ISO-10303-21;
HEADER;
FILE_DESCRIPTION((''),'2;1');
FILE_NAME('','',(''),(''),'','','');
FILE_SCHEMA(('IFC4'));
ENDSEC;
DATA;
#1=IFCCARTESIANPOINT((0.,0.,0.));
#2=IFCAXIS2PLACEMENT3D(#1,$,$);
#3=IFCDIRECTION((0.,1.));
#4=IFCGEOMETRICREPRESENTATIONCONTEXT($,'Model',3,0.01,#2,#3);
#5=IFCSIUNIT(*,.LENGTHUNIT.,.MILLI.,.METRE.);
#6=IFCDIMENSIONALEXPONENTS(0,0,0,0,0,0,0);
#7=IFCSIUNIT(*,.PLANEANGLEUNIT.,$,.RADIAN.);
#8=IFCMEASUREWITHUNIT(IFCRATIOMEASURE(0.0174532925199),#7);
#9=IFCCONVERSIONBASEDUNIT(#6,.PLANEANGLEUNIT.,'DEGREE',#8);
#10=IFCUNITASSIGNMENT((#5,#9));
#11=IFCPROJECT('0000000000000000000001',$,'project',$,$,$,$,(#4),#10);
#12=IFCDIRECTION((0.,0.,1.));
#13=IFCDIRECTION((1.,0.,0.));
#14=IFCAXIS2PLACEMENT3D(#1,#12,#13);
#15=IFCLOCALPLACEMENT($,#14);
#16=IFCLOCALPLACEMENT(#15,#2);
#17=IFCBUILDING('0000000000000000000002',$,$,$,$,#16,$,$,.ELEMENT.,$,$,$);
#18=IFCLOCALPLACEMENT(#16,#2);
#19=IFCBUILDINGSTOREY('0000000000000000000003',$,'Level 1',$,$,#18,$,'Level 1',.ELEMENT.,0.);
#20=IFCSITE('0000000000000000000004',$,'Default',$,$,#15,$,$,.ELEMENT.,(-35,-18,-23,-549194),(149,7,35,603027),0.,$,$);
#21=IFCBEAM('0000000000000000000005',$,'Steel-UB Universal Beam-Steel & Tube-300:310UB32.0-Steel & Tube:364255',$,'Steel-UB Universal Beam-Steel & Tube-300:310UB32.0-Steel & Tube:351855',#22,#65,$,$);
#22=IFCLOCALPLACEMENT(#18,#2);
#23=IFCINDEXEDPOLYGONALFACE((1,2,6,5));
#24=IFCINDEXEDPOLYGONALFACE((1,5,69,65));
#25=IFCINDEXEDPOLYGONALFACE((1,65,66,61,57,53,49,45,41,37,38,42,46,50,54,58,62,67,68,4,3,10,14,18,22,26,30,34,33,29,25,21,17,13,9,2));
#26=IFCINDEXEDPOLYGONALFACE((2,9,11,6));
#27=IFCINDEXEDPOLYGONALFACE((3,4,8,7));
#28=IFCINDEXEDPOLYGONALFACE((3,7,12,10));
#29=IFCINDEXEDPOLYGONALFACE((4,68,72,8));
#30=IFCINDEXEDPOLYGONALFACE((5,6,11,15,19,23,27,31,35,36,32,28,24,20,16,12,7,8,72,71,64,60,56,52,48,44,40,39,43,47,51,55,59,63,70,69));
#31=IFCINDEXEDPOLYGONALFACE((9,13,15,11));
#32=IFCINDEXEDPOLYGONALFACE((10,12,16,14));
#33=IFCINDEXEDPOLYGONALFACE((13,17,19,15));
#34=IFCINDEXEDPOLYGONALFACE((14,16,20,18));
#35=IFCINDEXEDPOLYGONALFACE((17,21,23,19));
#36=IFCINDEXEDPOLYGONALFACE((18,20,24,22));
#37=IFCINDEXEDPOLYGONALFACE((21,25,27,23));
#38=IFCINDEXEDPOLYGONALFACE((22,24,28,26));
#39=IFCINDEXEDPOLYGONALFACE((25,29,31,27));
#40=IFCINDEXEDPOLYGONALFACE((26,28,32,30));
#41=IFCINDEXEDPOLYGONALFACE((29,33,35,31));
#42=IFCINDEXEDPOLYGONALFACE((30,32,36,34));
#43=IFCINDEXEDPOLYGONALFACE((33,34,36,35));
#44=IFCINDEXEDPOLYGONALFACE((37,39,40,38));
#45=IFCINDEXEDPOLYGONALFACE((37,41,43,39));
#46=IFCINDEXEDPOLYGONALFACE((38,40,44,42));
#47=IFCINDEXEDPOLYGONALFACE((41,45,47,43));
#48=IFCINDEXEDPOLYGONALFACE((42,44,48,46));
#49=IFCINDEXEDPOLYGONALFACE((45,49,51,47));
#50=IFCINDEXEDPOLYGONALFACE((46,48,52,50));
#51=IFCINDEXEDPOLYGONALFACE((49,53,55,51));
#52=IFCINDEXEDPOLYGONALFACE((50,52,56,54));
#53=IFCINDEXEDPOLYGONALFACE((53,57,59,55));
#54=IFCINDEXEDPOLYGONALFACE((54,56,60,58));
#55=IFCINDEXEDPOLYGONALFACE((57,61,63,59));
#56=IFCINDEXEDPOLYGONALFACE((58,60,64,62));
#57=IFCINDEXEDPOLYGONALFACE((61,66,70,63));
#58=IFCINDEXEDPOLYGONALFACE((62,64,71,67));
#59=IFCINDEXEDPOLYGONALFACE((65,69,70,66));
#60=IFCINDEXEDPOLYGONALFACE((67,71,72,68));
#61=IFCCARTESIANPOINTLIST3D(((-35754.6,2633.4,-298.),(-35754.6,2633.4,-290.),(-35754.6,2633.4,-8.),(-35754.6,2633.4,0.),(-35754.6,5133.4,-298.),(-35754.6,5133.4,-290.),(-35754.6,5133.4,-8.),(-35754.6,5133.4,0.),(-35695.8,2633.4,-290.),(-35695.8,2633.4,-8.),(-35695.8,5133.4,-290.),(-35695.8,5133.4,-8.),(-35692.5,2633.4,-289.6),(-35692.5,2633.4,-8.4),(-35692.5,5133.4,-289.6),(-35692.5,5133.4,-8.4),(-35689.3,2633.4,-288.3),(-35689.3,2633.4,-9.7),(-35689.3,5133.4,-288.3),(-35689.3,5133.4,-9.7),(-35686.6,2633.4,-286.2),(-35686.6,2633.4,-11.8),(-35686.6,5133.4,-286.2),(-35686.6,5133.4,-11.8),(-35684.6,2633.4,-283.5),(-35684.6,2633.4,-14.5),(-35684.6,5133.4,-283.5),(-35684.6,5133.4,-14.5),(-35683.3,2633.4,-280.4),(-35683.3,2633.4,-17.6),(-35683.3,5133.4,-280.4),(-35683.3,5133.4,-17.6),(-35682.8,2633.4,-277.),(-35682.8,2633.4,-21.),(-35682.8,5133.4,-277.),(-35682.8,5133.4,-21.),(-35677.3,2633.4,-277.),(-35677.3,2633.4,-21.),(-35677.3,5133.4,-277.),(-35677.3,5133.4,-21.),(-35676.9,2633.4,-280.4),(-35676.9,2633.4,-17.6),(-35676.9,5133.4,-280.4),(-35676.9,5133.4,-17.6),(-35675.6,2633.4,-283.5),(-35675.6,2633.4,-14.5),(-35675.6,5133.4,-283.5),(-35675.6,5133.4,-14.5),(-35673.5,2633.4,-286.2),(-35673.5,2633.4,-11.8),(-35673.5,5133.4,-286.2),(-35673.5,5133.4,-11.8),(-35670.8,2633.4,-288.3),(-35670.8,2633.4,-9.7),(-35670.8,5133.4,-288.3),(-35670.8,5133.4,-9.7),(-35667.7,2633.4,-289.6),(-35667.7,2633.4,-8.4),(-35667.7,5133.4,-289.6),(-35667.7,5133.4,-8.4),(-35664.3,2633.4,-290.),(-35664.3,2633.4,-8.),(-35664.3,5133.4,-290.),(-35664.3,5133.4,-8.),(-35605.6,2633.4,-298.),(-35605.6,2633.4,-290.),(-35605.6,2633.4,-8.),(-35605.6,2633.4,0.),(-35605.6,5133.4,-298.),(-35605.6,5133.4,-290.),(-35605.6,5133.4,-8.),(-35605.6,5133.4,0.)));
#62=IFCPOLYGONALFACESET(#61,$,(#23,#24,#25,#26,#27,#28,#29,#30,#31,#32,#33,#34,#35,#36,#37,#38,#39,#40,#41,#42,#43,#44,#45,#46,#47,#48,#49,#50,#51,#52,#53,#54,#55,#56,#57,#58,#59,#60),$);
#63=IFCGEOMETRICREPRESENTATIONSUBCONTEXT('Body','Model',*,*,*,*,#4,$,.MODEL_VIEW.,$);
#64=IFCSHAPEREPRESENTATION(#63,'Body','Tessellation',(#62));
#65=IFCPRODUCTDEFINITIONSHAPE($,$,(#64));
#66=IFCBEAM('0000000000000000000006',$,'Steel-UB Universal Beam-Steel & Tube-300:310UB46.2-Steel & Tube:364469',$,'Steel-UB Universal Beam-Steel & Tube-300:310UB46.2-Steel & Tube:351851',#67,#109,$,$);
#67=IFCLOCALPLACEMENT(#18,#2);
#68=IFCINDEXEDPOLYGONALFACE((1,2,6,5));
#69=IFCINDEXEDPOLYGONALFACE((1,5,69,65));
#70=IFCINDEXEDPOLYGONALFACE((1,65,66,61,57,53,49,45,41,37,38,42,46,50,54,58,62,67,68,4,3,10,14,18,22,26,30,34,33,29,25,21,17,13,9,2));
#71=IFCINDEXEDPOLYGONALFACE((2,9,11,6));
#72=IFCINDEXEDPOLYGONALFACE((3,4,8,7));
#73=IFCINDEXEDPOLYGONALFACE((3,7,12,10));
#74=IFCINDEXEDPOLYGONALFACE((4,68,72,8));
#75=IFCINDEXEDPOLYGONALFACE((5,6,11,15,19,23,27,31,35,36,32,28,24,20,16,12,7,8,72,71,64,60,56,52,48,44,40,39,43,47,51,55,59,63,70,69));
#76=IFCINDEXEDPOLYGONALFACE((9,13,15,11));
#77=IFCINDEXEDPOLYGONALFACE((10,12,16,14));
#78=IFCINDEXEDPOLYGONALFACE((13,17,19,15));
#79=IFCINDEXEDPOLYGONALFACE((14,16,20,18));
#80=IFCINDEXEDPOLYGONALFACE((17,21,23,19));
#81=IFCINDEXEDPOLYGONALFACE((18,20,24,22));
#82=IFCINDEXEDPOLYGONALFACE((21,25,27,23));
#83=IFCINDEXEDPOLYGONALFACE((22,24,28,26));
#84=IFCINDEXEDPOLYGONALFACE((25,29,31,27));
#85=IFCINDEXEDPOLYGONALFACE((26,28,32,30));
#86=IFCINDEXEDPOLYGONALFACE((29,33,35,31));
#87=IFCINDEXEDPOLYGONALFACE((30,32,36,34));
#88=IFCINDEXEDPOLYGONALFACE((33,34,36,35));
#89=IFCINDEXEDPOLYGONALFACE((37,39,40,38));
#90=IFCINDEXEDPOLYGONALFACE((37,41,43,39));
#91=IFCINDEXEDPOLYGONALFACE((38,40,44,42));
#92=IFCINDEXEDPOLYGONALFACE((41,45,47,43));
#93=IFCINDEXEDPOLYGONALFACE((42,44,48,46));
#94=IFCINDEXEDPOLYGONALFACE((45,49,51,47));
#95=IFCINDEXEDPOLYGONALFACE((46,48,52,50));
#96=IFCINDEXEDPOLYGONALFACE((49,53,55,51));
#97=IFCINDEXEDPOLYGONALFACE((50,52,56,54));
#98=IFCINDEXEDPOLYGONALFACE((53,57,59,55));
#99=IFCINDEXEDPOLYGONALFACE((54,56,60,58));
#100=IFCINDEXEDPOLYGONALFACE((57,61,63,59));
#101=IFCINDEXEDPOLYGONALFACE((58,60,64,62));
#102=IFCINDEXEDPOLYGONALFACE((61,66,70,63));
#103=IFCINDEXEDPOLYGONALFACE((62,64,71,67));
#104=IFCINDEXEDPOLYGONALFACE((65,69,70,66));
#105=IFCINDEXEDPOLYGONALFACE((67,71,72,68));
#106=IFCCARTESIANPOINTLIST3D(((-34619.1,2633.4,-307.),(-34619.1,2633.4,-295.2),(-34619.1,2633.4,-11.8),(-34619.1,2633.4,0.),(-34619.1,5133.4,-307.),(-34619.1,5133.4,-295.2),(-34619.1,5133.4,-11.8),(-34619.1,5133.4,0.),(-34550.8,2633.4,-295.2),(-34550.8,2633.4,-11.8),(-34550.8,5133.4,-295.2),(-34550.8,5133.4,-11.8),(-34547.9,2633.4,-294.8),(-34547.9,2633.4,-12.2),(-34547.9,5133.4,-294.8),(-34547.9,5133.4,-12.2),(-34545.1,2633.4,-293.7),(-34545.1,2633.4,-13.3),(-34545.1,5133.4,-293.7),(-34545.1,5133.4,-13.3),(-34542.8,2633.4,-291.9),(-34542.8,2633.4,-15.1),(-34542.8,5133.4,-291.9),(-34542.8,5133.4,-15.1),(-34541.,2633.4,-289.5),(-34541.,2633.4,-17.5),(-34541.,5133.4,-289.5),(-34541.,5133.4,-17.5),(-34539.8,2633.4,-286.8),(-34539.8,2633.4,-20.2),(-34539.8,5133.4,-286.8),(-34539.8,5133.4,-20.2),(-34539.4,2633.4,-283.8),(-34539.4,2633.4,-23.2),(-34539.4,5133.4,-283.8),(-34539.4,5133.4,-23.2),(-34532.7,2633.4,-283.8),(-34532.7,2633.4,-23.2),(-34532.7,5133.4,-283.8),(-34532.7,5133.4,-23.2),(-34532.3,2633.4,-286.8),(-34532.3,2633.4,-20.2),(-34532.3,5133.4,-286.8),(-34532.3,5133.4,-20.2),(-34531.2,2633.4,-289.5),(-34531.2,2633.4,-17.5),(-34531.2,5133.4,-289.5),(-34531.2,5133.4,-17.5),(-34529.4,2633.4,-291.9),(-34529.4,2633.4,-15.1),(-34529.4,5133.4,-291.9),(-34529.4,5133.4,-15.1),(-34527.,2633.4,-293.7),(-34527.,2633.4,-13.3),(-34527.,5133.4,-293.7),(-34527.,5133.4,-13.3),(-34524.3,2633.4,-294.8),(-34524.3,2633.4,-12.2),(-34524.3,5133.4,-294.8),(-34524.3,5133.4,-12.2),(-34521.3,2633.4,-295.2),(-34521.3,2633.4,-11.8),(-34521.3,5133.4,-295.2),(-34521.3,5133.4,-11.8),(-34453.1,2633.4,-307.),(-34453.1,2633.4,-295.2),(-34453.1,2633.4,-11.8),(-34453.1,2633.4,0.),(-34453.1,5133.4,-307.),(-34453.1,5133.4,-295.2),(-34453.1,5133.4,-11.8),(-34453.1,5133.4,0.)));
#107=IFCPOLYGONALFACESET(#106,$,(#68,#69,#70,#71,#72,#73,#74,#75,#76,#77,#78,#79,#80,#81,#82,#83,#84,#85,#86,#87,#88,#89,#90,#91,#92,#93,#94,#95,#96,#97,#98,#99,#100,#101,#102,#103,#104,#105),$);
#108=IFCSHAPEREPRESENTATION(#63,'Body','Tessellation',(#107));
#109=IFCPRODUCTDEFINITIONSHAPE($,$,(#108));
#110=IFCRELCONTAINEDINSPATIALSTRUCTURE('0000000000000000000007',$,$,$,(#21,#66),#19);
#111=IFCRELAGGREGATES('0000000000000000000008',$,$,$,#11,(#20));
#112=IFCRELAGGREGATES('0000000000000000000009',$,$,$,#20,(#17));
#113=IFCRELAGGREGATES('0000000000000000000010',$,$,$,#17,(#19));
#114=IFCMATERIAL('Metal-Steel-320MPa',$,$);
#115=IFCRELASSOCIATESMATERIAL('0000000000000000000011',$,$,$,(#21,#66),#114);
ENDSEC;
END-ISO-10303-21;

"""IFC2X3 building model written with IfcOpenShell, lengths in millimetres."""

from ifc_helpers import new_model, entity, si_unit, converted_unit, direction, frame, frame_2d, origin, origin_with_axes, place, context, subcontext, project, spatial, polyline, circle_curve, parameter, trimmed, segment, composite_curve, outline, extrude, material, element, save


model = new_model("IFC2X3")

# Units and contexts
model_context = context("Model", 3, precision=0.01, world=origin(), true_north=direction((0.0, 1.0)))
body_context = subcontext(model_context, "Body", "Model", "MODEL_VIEW")
ifc_project = project(units=[si_unit("LENGTHUNIT", "METRE", prefix="MILLI"), converted_unit("PLANEANGLEUNIT", "DEGREE", entity("IfcRatioMeasure", 0.0174532925199), si_unit("PLANEANGLEUNIT", "RADIAN"), dimensions=[0, 0, 0, 0, 0, 0, 0])], contexts=[model_context])

# Site, building, storey
site_placement = place(None, origin_with_axes())
site = spatial("IfcSite", under=ifc_project, at=site_placement, Name="Default", CompositionType="ELEMENT", RefLatitude=(-35, -18, -23, -549194), RefLongitude=(149, 7, 35, 603027), RefElevation=0.0)
building_placement = place(site_placement, origin())
building = spatial("IfcBuilding", under=site, at=building_placement, CompositionType="ELEMENT")
storey_placement = place(building_placement, origin())
storey = spatial("IfcBuildingStorey", under=building, at=storey_placement, Name="Level 1", LongName="Level 1", CompositionType="ELEMENT", Elevation=0.0)

# Beams
ifc_material = material(Name="Metal-Steel-320MPa")
beam_1_placement = place(storey_placement, frame((-35680.1, 5133.4, 0.0), z_axis=(0.0, 0.0, 1.0), x_axis=(0.0, -1.0, 0.0)))
element("IfcBeam", 1, at=beam_1_placement, inside=storey, material=ifc_material, Name="Steel-UB Universal Beam-Steel & Tube-300:310UB32.0-Steel & Tube:364255", ObjectType="Steel-UB Universal Beam-Steel & Tube-300:310UB32.0-Steel & Tube:351855", context=body_context, shape_type="SweptSolid", body=[
    extrude(outline(composite_curve([segment(polyline([(141.0, -74.5), (149.0, -74.5)]), True, "CONTINUOUS"), segment(polyline([(149.0, -74.5), (149.0, 74.5)]), True, "CONTINUOUS"), segment(polyline([(149.0, 74.5), (141.0, 74.5)]), True, "CONTINUOUS"), segment(polyline([(141.0, 74.5), (141.0, 15.8)]), True, "CONTINUOUS"), segment(trimmed(circle_curve(frame_2d((128.0, 15.8), x_axis=(1.0, 0.0)), 13.0), [parameter(270.0)], [parameter(0.0)], True, "PARAMETER"), False, "CONTINUOUS"), segment(polyline([(128.0, 2.8), (-128.0, 2.8)]), True, "CONTINUOUS"), segment(trimmed(circle_curve(frame_2d((-128.0, 15.8), x_axis=(0.0, -1.0)), 13.0), [parameter(270.0)], [parameter(0.0)], True, "PARAMETER"), False, "CONTINUOUS"), segment(polyline([(-141.0, 15.8), (-141.0, 74.5)]), True, "CONTINUOUS"), segment(polyline([(-141.0, 74.5), (-149.0, 74.5)]), True, "CONTINUOUS"), segment(polyline([(-149.0, 74.5), (-149.0, -74.5)]), True, "CONTINUOUS"), segment(polyline([(-149.0, -74.5), (-141.0, -74.5)]), True, "CONTINUOUS"), segment(polyline([(-141.0, -74.5), (-141.0, -15.8)]), True, "CONTINUOUS"), segment(trimmed(circle_curve(frame_2d((-128.0, -15.8), x_axis=(-1.0, 0.0)), 13.0), [parameter(270.0)], [parameter(0.0)], True, "PARAMETER"), False, "CONTINUOUS"), segment(polyline([(-128.0, -2.8), (128.0, -2.8)]), True, "CONTINUOUS"), segment(trimmed(circle_curve(frame_2d((128.0, -15.8), x_axis=(0.0, 1.0)), 13.0), [parameter(270.0)], [parameter(0.0)], True, "PARAMETER"), False, "CONTINUOUS"), segment(polyline([(141.0, -15.8), (141.0, -74.5)]), True, "CONTINUOUS")], self_intersect=False)), frame((0.0, 0.0, -149.0), z_axis=(1.0, 0.0, 0.0), x_axis=(0.0, 0.0, -1.0)), (0.0, 0.0, 1.0), 2500.0),
])
beam_2_placement = place(storey_placement, frame((-34536.1, 5133.4, 0.0), z_axis=(0.0, 0.0, 1.0), x_axis=(0.0, -1.0, 0.0)))
element("IfcBeam", 2, at=beam_2_placement, inside=storey, material=ifc_material, Name="Steel-UB Universal Beam-Steel & Tube-300:310UB46.2-Steel & Tube:364469", ObjectType="Steel-UB Universal Beam-Steel & Tube-300:310UB46.2-Steel & Tube:351851", context=body_context, shape_type="SweptSolid", body=[
    extrude(outline(composite_curve([segment(polyline([(141.7, -83.0), (153.5, -83.0)]), True, "CONTINUOUS"), segment(polyline([(153.5, -83.0), (153.5, 83.0)]), True, "CONTINUOUS"), segment(polyline([(153.5, 83.0), (141.7, 83.0)]), True, "CONTINUOUS"), segment(polyline([(141.7, 83.0), (141.7, 14.8)]), True, "CONTINUOUS"), segment(trimmed(circle_curve(frame_2d((130.3, 14.8), x_axis=(1.0, 0.0)), 11.4), [parameter(270.0)], [parameter(0.0)], True, "PARAMETER"), False, "CONTINUOUS"), segment(polyline([(130.3, 3.4), (-130.3, 3.4)]), True, "CONTINUOUS"), segment(trimmed(circle_curve(frame_2d((-130.3, 14.8), x_axis=(0.0, -1.0)), 11.4), [parameter(270.0)], [parameter(0.0)], True, "PARAMETER"), False, "CONTINUOUS"), segment(polyline([(-141.7, 14.8), (-141.7, 83.0)]), True, "CONTINUOUS"), segment(polyline([(-141.7, 83.0), (-153.5, 83.0)]), True, "CONTINUOUS"), segment(polyline([(-153.5, 83.0), (-153.5, -83.0)]), True, "CONTINUOUS"), segment(polyline([(-153.5, -83.0), (-141.7, -83.0)]), True, "CONTINUOUS"), segment(polyline([(-141.7, -83.0), (-141.7, -14.8)]), True, "CONTINUOUS"), segment(trimmed(circle_curve(frame_2d((-130.3, -14.8), x_axis=(-1.0, 0.0)), 11.4), [parameter(270.0)], [parameter(0.0)], True, "PARAMETER"), False, "CONTINUOUS"), segment(polyline([(-130.3, -3.4), (130.3, -3.4)]), True, "CONTINUOUS"), segment(trimmed(circle_curve(frame_2d((130.3, -14.8), x_axis=(0.0, 1.0)), 11.4), [parameter(270.0)], [parameter(0.0)], True, "PARAMETER"), False, "CONTINUOUS"), segment(polyline([(141.7, -14.8), (141.7, -83.0)]), True, "CONTINUOUS")], self_intersect=False)), frame((0.0, 0.0, -153.5), z_axis=(1.0, 0.0, 0.0), x_axis=(0.0, 0.0, -1.0)), (0.0, 0.0, 1.0), 2500.0),
])

save(model, "model.ifc")
